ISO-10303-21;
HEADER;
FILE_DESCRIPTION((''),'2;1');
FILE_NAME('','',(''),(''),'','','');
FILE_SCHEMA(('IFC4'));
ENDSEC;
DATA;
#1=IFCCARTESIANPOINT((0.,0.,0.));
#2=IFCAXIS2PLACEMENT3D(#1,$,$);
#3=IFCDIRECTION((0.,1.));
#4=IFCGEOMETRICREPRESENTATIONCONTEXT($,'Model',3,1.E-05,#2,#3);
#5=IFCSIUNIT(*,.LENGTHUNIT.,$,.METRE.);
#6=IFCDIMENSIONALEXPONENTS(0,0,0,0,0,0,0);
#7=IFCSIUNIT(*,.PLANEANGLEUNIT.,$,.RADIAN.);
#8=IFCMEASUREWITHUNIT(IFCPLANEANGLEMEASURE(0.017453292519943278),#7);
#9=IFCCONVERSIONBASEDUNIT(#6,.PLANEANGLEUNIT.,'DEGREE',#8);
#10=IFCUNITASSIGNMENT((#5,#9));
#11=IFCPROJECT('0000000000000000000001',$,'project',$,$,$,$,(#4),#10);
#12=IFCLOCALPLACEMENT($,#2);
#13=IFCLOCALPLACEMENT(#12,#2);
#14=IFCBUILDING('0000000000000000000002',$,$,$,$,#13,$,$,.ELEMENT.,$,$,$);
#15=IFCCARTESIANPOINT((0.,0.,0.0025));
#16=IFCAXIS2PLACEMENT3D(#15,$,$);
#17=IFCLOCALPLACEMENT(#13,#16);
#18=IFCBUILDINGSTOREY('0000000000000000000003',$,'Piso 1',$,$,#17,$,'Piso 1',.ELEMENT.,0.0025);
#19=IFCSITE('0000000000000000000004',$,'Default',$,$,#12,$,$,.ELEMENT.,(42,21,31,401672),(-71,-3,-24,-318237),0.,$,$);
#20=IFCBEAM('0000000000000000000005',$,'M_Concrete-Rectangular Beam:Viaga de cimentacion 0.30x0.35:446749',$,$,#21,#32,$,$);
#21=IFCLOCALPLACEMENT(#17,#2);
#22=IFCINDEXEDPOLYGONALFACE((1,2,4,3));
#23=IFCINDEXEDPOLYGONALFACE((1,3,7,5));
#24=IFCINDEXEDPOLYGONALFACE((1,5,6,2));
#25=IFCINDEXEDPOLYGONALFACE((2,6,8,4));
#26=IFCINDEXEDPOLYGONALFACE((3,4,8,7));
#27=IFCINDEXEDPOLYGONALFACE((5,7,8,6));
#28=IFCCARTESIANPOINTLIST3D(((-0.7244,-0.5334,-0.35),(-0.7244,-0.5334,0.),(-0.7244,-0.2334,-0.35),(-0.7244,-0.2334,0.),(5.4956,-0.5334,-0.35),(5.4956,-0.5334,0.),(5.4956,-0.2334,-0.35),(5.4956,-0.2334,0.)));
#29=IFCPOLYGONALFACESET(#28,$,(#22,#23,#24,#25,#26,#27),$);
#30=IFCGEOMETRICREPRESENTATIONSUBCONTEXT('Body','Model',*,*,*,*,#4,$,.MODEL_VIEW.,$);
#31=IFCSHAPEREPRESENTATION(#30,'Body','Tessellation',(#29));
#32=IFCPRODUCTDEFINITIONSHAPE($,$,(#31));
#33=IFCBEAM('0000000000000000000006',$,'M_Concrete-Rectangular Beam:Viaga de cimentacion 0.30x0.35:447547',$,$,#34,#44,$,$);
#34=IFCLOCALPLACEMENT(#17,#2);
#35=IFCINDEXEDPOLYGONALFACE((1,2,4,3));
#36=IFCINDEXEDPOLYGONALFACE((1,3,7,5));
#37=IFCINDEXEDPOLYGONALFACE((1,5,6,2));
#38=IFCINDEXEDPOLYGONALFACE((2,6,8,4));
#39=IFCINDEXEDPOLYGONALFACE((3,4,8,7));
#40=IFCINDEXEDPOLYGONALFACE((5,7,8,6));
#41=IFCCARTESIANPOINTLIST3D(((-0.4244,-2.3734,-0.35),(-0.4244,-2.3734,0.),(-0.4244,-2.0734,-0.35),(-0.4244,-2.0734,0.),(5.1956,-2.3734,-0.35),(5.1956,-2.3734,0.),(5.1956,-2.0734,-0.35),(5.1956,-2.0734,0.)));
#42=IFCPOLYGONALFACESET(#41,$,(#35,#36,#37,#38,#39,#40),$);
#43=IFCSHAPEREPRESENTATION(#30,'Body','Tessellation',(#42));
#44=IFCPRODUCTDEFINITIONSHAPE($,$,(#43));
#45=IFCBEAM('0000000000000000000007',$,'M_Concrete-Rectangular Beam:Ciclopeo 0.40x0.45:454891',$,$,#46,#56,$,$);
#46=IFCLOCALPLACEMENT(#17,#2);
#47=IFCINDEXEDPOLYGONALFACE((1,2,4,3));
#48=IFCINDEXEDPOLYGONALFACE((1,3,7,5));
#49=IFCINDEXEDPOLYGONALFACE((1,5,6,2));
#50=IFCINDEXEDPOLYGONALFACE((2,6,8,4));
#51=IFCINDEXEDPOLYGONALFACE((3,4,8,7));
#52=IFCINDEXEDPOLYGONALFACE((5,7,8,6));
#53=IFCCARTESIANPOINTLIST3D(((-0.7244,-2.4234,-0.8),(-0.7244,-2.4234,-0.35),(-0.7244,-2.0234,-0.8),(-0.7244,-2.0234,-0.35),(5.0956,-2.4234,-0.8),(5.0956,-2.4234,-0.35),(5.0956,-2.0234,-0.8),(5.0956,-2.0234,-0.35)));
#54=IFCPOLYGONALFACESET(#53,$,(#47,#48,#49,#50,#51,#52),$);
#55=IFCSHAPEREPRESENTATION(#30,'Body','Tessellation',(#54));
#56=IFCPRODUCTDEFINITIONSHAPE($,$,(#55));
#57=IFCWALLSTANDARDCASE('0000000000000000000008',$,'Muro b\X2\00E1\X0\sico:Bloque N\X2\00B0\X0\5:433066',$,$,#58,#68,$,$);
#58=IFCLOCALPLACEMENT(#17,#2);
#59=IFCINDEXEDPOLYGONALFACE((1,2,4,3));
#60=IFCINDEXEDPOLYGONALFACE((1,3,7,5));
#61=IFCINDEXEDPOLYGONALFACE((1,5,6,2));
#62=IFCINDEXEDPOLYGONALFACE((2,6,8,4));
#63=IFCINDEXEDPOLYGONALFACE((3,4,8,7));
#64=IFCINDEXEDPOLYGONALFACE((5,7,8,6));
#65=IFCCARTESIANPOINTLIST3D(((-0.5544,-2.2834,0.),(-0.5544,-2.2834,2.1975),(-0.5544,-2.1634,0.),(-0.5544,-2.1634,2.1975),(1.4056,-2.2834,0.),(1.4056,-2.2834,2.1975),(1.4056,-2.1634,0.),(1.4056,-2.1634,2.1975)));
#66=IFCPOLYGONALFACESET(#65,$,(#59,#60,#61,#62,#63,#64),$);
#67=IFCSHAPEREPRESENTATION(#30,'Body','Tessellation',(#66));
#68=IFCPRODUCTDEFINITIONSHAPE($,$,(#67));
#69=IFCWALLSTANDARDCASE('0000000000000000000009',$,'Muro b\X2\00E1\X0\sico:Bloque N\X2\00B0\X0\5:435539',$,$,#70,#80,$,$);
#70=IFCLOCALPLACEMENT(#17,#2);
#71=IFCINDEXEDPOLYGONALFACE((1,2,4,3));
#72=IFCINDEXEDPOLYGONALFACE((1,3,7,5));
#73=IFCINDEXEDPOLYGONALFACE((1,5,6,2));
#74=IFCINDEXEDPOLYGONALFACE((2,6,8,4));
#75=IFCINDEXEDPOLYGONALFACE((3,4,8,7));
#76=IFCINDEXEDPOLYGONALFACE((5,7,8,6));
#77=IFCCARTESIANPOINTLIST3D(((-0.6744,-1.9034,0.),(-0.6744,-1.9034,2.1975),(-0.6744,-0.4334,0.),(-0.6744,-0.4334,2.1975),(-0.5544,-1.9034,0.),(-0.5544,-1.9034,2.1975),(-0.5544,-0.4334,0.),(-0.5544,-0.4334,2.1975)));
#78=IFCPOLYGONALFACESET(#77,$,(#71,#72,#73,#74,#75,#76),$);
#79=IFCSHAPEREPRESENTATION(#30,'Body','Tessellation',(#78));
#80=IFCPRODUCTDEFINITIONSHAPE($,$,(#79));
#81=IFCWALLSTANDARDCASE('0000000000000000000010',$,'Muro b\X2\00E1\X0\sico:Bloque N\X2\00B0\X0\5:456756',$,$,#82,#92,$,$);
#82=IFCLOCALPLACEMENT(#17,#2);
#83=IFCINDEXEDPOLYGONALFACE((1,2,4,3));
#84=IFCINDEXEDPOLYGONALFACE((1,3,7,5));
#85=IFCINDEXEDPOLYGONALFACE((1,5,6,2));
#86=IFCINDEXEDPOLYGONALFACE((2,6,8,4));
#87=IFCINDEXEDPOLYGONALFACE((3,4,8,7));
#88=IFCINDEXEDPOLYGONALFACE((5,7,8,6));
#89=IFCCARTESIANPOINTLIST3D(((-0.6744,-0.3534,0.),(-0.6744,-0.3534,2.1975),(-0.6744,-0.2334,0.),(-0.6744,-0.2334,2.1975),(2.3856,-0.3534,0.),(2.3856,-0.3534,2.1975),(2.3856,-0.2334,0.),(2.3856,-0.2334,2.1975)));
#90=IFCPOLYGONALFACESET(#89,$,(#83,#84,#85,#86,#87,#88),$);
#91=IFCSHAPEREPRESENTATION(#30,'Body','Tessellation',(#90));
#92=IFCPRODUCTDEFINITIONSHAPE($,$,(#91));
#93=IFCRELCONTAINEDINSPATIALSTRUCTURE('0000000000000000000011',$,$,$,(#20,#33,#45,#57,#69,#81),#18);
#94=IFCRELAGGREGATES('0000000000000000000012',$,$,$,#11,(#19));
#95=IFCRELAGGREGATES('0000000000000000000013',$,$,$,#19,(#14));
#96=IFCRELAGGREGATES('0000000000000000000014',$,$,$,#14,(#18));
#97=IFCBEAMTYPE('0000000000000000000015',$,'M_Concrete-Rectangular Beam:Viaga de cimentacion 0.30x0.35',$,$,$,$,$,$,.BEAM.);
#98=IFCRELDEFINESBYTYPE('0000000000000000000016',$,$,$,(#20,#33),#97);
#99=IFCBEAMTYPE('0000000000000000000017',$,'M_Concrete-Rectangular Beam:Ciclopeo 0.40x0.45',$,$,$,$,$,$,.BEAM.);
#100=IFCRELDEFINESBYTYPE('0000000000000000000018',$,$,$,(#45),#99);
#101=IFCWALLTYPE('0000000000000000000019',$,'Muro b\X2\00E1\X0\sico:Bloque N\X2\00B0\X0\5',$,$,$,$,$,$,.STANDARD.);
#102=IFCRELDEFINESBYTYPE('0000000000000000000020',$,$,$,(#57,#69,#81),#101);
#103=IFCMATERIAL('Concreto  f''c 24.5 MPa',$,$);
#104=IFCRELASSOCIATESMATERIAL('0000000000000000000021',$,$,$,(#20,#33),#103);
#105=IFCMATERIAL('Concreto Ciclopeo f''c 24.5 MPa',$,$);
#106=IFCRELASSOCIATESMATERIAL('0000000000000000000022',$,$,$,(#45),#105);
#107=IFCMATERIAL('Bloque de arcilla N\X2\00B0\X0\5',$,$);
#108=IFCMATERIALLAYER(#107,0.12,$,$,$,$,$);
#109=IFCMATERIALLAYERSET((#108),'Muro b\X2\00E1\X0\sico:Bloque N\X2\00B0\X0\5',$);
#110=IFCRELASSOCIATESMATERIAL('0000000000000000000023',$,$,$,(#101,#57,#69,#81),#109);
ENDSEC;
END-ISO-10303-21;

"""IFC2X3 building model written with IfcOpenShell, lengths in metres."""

from ifc_helpers import new_model, entity, si_unit, converted_unit, direction, frame, frame_2d, origin, place, context, subcontext, project, spatial, rectangle, extrude, material, layer, layer_set, layer_usage, type_object, element, save


model = new_model("IFC2X3")

# Units and contexts
model_context = context("Model", 3, precision=1e-05, world=origin(), true_north=direction((0.0, 1.0)))
body_context = subcontext(model_context, "Body", "Model", "MODEL_VIEW")
ifc_project = project(units=[si_unit("LENGTHUNIT", "METRE"), converted_unit("PLANEANGLEUNIT", "DEGREE", entity("IfcPlaneAngleMeasure", 0.017453292519943278), si_unit("PLANEANGLEUNIT", "RADIAN"), dimensions=[0, 0, 0, 0, 0, 0, 0])], contexts=[model_context])

# Site, building, storey
site_placement = place(None, origin())
site = spatial("IfcSite", under=ifc_project, at=site_placement, Name="Default", CompositionType="ELEMENT", RefLatitude=(42, 21, 31, 401672), RefLongitude=(-71, -3, -24, -318237), RefElevation=0.0)
building_placement = place(site_placement, origin())
building = spatial("IfcBuilding", under=site, at=building_placement, CompositionType="ELEMENT")
storey_placement = place(building_placement, frame((0.0, 0.0, 0.0025)))
storey = spatial("IfcBuildingStorey", under=building, at=storey_placement, Name="Piso 1", LongName="Piso 1", CompositionType="ELEMENT", Elevation=0.0025)

# Beams
ifc_material_1 = material(Name="Concreto  f'c 24.5 MPa")
beam_type_1 = type_object("IfcBeamType", Name="M_Concrete-Rectangular Beam:Viaga de cimentacion 0.30x0.35", PredefinedType="BEAM")
beam_1_placement = place(storey_placement, frame((-0.5744, -0.3834, 0.0)))
element("IfcBeam", 1, at=beam_1_placement, inside=storey, type_object=beam_type_1, material=ifc_material_1, Name="M_Concrete-Rectangular Beam:Viaga de cimentacion 0.30x0.35:446749", context=body_context, shape_type="SweptSolid", body=[
    extrude(rectangle(XDim=0.35, YDim=0.3, at=frame_2d((0.0, 0.0), x_axis=(1.0, 0.0))), frame((-0.15, 0.0, -0.175), z_axis=(1.0, 0.0, 0.0), x_axis=(0.0, 0.0, -1.0)), (0.0, 0.0, 1.0), 6.22),
])
beam_2_placement = place(storey_placement, frame((-0.5744, -2.2234, 0.0)))
element("IfcBeam", 2, at=beam_2_placement, inside=storey, type_object=beam_type_1, material=ifc_material_1, Name="M_Concrete-Rectangular Beam:Viaga de cimentacion 0.30x0.35:447547", context=body_context, shape_type="SweptSolid", body=[
    extrude(rectangle(XDim=0.35, YDim=0.3, at=frame_2d((0.0, 0.0), x_axis=(1.0, 0.0))), frame((0.15, 0.0, -0.175), z_axis=(1.0, 0.0, 0.0), x_axis=(0.0, 0.0, -1.0)), (0.0, 0.0, 1.0), 5.62),
])
ifc_material_2 = material(Name="Concreto Ciclopeo f'c 24.5 MPa")
beam_type_2 = type_object("IfcBeamType", Name="M_Concrete-Rectangular Beam:Ciclopeo 0.40x0.45", PredefinedType="BEAM")
beam_3_placement = place(storey_placement, frame((-0.5244, -2.2234, -0.35)))
element("IfcBeam", 3, at=beam_3_placement, inside=storey, type_object=beam_type_2, material=ifc_material_2, Name="M_Concrete-Rectangular Beam:Ciclopeo 0.40x0.45:454891", context=body_context, shape_type="SweptSolid", body=[
    extrude(rectangle(XDim=0.45, YDim=0.4, at=frame_2d((0.0, 0.0), x_axis=(1.0, 0.0))), frame((-0.2, 0.0, -0.225), z_axis=(1.0, 0.0, 0.0), x_axis=(0.0, 0.0, -1.0)), (0.0, 0.0, 1.0), 5.82),
])

# Walls
ifc_material_3 = material(Name="Bloque de arcilla N°5")
ifc_layer = layer(ifc_material_3, 0.12)
ifc_layer_set = layer_set([ifc_layer], Name="Muro básico:Bloque N°5")
ifc_layer_usage_1 = layer_usage(ifc_layer_set, "AXIS2", "NEGATIVE", 0.06)
wall_type = type_object("IfcWallType", Name="Muro básico:Bloque N°5", PredefinedType="STANDARD", material=ifc_layer_set)
wall_1_placement = place(storey_placement, frame((-0.5544, -2.2234, 0.0)))
element("IfcWallStandardCase", 4, at=wall_1_placement, inside=storey, type_object=wall_type, material=ifc_layer_usage_1, Name="Muro básico:Bloque N°5:433066", context=body_context, shape_type="SweptSolid", body=[
    extrude(rectangle(XDim=1.96, YDim=0.12, at=frame_2d((0.98, 0.0), x_axis=(-1.0, 0.0))), origin(), (0.0, 0.0, 1.0), 2.1975),
])
ifc_layer_usage_2 = layer_usage(ifc_layer_set, "AXIS2", "NEGATIVE", 0.06)
wall_2_placement = place(storey_placement, frame((-0.6144, -0.4334, 0.0), z_axis=(0.0, 0.0, 1.0), x_axis=(0.0, -1.0, 0.0)))
element("IfcWallStandardCase", 5, at=wall_2_placement, inside=storey, type_object=wall_type, material=ifc_layer_usage_2, Name="Muro básico:Bloque N°5:435539", context=body_context, shape_type="SweptSolid", body=[
    extrude(rectangle(XDim=1.47, YDim=0.12, at=frame_2d((0.735, 0.0), x_axis=(-1.0, 0.0))), origin(), (0.0, 0.0, 1.0), 2.1975),
])
ifc_layer_usage_3 = layer_usage(ifc_layer_set, "AXIS2", "NEGATIVE", 0.06)
wall_3_placement = place(storey_placement, frame((-0.6744, -0.2934, 0.0)))
element("IfcWallStandardCase", 6, at=wall_3_placement, inside=storey, type_object=wall_type, material=ifc_layer_usage_3, Name="Muro básico:Bloque N°5:456756", context=body_context, shape_type="SweptSolid", body=[
    extrude(rectangle(XDim=3.06, YDim=0.12, at=frame_2d((1.53, 0.0), x_axis=(-1.0, 0.0))), origin(), (0.0, 0.0, 1.0), 2.1975),
])

save(model, "model.ifc")
